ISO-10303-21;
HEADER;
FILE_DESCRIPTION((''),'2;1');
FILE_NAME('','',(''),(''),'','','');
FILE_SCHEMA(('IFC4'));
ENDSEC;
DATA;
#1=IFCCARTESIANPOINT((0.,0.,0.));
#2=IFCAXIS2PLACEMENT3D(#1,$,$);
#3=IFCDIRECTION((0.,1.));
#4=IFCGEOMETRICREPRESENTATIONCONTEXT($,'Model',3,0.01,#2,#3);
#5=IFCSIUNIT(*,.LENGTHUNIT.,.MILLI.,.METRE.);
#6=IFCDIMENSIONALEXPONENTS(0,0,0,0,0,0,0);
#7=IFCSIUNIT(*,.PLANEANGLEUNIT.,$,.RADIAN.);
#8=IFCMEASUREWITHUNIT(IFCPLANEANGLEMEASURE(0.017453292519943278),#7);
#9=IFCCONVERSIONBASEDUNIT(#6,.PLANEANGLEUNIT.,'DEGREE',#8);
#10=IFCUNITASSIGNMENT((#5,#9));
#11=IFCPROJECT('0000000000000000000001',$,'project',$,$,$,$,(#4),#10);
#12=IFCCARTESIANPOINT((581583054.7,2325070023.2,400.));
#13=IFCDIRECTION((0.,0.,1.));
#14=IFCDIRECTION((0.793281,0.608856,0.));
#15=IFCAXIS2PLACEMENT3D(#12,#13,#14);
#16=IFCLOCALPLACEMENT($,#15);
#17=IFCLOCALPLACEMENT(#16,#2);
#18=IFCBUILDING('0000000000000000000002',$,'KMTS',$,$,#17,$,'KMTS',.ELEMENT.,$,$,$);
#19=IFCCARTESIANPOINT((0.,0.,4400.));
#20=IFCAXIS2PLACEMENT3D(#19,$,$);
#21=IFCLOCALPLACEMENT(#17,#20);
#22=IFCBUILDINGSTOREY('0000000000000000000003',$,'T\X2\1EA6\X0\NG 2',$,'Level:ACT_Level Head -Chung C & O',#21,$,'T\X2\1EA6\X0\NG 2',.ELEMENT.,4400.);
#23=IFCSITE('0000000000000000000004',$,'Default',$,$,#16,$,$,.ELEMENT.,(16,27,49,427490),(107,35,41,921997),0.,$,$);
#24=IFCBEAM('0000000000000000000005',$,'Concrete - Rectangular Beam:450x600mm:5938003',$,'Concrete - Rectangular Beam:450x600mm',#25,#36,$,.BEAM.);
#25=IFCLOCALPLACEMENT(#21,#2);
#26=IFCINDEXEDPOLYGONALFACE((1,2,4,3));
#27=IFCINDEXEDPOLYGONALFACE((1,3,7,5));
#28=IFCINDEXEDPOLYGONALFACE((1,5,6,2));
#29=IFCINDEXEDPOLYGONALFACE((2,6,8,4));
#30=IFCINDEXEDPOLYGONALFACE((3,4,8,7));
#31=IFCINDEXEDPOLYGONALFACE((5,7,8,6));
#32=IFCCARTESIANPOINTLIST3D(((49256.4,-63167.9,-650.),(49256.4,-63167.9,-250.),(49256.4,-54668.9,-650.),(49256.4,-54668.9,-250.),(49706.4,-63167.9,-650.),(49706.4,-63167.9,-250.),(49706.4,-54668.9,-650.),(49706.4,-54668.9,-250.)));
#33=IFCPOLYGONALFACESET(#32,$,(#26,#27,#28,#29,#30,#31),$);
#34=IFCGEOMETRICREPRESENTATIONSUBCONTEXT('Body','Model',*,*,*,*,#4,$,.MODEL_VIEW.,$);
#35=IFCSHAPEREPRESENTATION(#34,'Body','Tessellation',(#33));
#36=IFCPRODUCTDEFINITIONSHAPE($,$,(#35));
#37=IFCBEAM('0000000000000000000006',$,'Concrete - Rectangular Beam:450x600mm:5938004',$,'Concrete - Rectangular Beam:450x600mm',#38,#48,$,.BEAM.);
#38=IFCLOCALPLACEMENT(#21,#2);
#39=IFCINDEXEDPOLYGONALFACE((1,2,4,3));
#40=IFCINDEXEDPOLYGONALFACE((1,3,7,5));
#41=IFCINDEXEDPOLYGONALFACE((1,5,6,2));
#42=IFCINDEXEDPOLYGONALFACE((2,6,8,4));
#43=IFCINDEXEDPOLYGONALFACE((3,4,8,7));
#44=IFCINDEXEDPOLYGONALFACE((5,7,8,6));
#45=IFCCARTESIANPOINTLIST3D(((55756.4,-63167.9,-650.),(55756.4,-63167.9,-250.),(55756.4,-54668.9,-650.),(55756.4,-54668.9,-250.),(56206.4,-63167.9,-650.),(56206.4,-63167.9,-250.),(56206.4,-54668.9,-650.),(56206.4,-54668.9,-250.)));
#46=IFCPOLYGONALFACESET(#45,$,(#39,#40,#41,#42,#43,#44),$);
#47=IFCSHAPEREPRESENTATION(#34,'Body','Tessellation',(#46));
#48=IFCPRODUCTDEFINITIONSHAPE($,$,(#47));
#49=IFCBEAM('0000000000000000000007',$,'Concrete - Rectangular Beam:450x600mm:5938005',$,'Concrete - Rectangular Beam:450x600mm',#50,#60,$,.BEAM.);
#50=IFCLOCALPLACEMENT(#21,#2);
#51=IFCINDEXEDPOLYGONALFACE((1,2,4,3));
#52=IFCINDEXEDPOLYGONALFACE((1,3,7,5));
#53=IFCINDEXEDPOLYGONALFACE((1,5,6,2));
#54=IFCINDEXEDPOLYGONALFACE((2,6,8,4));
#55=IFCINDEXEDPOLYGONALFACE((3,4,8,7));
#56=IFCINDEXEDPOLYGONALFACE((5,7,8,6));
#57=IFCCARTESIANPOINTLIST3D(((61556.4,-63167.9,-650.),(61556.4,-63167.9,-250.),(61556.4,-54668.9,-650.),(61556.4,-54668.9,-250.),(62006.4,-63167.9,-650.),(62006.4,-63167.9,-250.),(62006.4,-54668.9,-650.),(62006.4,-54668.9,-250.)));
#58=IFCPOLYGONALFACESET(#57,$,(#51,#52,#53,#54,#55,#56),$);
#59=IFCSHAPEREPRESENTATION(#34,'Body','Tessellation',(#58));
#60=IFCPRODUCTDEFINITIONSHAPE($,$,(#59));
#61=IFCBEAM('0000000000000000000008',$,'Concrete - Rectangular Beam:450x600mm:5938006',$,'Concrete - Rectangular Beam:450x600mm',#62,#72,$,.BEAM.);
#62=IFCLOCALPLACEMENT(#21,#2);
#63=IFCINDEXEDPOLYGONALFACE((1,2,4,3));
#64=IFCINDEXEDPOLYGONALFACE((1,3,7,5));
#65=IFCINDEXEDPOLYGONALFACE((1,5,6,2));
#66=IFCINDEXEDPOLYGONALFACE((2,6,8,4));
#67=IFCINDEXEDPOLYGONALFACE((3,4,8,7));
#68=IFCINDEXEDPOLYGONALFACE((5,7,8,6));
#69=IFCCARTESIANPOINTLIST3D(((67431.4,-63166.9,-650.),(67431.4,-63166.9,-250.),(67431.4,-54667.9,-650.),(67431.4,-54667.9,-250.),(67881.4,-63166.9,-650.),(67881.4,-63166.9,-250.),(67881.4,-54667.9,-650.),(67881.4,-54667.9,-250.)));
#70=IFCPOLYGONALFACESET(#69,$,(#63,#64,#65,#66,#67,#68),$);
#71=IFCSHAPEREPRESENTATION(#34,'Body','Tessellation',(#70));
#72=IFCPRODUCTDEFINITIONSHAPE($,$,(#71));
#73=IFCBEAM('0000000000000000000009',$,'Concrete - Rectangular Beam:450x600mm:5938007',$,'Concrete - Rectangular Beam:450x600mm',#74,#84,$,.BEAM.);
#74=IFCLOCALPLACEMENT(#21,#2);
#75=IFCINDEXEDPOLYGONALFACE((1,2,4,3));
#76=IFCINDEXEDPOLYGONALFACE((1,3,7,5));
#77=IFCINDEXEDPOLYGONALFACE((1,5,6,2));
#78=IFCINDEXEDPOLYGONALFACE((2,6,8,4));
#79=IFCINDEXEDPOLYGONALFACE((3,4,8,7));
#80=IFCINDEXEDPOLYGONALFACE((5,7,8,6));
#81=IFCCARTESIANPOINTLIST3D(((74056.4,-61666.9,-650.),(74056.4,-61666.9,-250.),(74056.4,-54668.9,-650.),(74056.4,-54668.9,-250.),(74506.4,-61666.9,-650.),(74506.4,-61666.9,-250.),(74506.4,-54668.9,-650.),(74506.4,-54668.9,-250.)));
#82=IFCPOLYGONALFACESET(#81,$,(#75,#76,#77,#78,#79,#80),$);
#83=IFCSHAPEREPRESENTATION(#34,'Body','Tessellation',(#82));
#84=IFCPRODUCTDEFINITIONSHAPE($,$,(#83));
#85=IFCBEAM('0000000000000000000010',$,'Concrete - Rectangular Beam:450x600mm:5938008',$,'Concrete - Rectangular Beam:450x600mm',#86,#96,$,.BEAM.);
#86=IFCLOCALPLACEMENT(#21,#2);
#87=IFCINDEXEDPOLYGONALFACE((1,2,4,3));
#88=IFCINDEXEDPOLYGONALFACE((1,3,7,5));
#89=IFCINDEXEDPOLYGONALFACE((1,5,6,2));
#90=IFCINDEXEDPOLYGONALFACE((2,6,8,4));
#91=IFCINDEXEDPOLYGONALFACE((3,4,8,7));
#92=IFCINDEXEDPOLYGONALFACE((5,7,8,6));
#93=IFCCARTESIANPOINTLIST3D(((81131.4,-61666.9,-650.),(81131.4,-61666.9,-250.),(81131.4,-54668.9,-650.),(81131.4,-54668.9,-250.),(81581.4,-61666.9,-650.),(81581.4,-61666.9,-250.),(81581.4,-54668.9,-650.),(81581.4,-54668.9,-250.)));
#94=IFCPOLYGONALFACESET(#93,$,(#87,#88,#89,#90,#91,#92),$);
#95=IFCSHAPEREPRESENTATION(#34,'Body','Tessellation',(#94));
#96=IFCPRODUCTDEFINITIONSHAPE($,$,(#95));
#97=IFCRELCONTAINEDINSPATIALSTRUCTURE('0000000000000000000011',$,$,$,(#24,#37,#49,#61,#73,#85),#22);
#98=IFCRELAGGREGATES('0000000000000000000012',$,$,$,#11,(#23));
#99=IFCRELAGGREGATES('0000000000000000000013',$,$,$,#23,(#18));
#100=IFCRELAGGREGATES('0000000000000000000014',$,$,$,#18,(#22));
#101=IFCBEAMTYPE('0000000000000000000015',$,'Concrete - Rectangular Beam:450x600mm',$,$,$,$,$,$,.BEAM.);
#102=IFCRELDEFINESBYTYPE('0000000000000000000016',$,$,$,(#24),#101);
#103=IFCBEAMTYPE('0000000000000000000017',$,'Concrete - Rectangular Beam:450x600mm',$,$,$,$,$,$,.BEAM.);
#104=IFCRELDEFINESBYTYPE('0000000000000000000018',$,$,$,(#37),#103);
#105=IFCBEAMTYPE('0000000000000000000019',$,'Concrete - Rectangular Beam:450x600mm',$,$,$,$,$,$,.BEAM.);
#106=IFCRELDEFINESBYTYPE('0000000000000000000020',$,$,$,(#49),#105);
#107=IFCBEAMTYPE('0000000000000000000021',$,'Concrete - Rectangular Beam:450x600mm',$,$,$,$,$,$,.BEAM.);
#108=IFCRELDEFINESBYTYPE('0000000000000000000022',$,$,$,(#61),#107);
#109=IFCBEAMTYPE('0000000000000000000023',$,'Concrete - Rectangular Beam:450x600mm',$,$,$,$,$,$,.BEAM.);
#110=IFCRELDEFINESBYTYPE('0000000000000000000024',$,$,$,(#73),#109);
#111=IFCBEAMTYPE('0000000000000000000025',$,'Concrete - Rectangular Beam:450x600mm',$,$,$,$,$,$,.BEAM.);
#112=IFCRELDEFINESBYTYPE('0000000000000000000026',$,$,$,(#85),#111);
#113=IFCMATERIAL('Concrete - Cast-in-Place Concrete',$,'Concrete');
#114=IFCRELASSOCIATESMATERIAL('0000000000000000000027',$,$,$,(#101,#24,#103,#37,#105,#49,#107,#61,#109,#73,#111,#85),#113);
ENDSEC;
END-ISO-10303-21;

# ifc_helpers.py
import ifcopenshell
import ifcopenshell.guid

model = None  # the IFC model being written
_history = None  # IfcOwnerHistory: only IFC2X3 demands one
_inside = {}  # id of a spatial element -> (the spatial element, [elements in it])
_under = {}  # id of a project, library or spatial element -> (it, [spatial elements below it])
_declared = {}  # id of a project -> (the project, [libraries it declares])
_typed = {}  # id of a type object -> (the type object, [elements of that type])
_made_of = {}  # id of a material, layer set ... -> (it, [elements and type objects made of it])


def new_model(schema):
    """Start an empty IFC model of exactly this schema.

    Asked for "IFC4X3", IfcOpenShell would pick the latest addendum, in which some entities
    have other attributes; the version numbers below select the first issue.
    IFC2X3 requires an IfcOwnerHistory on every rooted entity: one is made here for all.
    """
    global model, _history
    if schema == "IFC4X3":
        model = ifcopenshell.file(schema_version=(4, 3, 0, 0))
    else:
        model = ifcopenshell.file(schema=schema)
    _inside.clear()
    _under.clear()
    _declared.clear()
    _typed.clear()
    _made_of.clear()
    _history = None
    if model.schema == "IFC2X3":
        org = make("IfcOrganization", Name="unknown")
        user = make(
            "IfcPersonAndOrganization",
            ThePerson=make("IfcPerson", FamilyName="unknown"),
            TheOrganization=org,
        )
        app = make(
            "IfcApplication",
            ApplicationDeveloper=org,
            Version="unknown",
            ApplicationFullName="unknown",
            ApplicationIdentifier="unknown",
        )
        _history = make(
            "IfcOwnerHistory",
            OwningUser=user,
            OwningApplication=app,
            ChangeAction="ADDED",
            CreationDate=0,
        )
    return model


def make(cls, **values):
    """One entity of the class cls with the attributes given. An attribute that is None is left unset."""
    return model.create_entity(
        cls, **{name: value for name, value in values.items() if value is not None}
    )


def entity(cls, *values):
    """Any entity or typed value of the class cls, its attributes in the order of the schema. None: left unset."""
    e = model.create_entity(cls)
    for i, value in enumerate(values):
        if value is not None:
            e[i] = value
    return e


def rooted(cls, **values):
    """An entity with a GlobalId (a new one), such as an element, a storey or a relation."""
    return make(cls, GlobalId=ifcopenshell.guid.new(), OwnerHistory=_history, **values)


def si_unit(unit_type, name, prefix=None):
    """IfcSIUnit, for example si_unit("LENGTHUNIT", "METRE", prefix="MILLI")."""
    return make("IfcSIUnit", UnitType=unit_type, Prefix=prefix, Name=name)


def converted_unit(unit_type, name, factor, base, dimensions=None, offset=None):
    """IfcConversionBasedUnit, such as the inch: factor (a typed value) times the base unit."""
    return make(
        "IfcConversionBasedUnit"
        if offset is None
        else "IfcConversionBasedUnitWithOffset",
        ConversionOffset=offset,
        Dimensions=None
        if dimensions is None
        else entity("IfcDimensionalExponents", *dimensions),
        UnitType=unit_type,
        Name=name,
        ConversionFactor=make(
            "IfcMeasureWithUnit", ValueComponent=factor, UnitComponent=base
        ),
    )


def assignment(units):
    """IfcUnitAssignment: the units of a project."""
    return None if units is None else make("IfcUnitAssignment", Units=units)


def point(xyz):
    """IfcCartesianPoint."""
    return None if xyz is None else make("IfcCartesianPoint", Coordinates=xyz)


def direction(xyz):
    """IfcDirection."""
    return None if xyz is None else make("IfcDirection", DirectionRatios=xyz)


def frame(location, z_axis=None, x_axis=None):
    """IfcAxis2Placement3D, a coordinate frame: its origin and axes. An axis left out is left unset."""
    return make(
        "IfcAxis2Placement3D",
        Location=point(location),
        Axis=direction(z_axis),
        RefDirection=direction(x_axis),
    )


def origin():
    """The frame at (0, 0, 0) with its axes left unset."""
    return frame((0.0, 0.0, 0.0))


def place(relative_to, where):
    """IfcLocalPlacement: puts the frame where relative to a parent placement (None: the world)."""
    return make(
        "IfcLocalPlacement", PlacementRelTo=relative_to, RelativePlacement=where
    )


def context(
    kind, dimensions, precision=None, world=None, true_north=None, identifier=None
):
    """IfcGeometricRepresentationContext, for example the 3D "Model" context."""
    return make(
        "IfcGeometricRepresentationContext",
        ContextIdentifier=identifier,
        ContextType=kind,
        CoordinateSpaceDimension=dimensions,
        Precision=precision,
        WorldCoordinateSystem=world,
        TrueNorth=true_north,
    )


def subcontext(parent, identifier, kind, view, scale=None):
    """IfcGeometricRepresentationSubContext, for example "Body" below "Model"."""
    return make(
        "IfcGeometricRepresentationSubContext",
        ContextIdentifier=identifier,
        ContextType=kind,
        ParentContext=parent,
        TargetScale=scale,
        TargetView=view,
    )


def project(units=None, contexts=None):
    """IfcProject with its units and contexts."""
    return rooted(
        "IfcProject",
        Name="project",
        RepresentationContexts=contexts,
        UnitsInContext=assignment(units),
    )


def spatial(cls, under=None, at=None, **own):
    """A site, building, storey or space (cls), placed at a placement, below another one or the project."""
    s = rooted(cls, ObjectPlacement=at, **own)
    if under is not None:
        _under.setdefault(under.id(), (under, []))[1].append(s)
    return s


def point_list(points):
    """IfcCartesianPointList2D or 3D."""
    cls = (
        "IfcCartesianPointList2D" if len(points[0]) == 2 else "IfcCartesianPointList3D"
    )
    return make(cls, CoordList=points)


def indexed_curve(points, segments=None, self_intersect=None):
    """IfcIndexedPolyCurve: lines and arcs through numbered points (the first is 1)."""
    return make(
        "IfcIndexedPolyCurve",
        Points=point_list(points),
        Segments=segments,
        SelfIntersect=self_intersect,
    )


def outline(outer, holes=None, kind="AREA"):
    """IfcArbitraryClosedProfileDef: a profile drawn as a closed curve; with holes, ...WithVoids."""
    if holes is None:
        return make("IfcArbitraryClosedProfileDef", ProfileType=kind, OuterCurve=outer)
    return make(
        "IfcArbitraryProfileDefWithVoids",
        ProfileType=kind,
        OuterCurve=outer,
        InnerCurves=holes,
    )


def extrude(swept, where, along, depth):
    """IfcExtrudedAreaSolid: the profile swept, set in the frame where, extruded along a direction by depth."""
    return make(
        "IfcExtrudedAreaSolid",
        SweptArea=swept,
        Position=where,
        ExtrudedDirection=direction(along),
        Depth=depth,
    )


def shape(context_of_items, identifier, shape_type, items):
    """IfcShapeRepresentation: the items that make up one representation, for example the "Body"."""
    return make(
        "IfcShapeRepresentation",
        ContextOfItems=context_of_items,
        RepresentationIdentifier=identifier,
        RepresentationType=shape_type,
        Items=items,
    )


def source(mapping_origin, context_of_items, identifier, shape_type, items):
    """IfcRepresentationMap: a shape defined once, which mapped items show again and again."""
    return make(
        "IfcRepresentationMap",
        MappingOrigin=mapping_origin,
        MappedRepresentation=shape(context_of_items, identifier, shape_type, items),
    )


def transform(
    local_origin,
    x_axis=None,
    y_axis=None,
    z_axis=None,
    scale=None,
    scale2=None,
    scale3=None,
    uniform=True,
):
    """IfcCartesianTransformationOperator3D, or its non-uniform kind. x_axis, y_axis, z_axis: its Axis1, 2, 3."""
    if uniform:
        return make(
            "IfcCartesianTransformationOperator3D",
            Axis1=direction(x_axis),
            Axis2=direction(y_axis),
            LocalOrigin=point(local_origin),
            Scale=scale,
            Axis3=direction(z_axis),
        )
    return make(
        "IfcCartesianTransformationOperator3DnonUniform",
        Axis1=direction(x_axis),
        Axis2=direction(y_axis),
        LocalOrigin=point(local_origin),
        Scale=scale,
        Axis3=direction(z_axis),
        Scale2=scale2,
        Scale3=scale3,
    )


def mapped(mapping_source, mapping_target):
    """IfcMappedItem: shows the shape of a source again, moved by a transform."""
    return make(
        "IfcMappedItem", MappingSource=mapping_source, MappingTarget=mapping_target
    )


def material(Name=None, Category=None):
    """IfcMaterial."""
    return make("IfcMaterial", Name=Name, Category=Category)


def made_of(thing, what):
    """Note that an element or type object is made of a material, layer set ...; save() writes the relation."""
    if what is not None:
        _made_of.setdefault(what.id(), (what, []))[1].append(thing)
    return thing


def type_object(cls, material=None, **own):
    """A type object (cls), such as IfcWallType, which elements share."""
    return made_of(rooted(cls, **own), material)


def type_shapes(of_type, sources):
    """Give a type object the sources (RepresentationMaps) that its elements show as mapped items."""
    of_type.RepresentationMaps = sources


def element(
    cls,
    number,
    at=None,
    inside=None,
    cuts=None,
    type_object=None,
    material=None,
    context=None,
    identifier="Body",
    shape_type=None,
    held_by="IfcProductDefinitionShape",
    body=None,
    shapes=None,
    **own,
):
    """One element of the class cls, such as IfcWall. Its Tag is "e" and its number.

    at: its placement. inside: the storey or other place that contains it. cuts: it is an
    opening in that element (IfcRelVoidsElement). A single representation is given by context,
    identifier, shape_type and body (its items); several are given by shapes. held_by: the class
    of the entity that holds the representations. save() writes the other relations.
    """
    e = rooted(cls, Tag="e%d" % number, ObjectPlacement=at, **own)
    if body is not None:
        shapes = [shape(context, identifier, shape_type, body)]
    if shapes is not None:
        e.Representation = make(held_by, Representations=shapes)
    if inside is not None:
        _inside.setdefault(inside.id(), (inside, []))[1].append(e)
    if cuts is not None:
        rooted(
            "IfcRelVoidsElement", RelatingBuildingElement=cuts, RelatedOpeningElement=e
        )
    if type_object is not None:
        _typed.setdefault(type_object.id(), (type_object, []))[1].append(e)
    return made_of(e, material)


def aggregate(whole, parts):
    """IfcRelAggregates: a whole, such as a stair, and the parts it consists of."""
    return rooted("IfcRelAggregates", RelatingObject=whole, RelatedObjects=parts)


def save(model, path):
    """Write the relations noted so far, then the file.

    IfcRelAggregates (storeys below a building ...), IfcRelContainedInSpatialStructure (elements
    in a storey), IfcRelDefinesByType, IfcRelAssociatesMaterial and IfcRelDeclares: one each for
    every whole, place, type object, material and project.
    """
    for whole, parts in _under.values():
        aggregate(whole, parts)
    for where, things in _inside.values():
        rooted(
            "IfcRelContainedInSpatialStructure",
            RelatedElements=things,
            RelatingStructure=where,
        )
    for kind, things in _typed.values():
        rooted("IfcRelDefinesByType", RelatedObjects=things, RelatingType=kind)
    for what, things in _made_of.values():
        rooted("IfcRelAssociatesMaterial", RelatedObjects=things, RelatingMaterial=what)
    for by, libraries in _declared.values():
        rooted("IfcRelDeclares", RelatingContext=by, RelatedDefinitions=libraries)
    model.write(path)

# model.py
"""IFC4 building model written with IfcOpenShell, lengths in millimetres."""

from ifc_helpers import new_model, entity, si_unit, converted_unit, direction, frame, origin, place, context, subcontext, project, spatial, indexed_curve, outline, extrude, source, transform, mapped, material, type_object, type_shapes, element, save


model = new_model("IFC4")

# Units and contexts
model_context = context("Model", 3, precision=0.01, world=origin(), true_north=direction((0.0, 1.0)))
body_context = subcontext(model_context, "Body", "Model", "MODEL_VIEW")
ifc_project = project(units=[si_unit("LENGTHUNIT", "METRE", prefix="MILLI"), converted_unit("PLANEANGLEUNIT", "DEGREE", entity("IfcPlaneAngleMeasure", 0.017453292519943278), si_unit("PLANEANGLEUNIT", "RADIAN"), dimensions=[0, 0, 0, 0, 0, 0, 0])], contexts=[model_context])

# Site, building, storey
site_placement = place(None, frame((581583054.7, 2325070023.2, 400.0), z_axis=(0.0, 0.0, 1.0), x_axis=(0.793281, 0.608856, 0.0)))
site = spatial("IfcSite", under=ifc_project, at=site_placement, Name="Default", CompositionType="ELEMENT", RefLatitude=(16, 27, 49, 427490), RefLongitude=(107, 35, 41, 921997), RefElevation=0.0)
building_placement = place(site_placement, origin())
building = spatial("IfcBuilding", under=site, at=building_placement, Name="KMTS", LongName="KMTS", CompositionType="ELEMENT")
storey_placement = place(building_placement, frame((0.0, 0.0, 4400.0)))
storey = spatial("IfcBuildingStorey", under=building, at=storey_placement, Name="TẦNG 2", ObjectType="Level:ACT_Level Head -Chung C & O", LongName="TẦNG 2", CompositionType="ELEMENT", Elevation=4400.0)

# Beams
ifc_material = material(Name="Concrete - Cast-in-Place Concrete", Category="Concrete")
beam_type_1 = type_object("IfcBeamType", Name="Concrete - Rectangular Beam:450x600mm", PredefinedType="BEAM", material=ifc_material)
shared_shape_1 = source(origin(), body_context, "Body", "SweptSolid", [
    extrude(outline(indexed_curve([(-225.0, -200.0), (225.0, -200.0), (225.0, 200.0), (-225.0, 200.0), (-225.0, -200.0)], self_intersect=False)), frame((49481.4, -54668.9, 3950.0), z_axis=(0.0, -1.0, 0.0), x_axis=(-1.0, 0.0, 0.0)), (0.0, 0.0, 1.0), 8499.0),
])
type_shapes(beam_type_1, [shared_shape_1])
beam_1_placement = place(storey_placement, frame((0.0, 0.0, -4400.0)))
element("IfcBeam", 1, at=beam_1_placement, inside=storey, type_object=beam_type_1, material=ifc_material, Name="Concrete - Rectangular Beam:450x600mm:5938003", ObjectType="Concrete - Rectangular Beam:450x600mm", PredefinedType="BEAM", context=body_context, shape_type="MappedRepresentation", body=[
    mapped(shared_shape_1, transform((0.0, 0.0, 0.0), scale=1.0)),
])
beam_type_2 = type_object("IfcBeamType", Name="Concrete - Rectangular Beam:450x600mm", PredefinedType="BEAM", material=ifc_material)
shared_shape_2 = source(origin(), body_context, "Body", "SweptSolid", [
    extrude(outline(indexed_curve([(-225.0, -200.0), (225.0, -200.0), (225.0, 200.0), (-225.0, 200.0), (-225.0, -200.0)], self_intersect=False)), frame((55981.4, -54668.9, 3950.0), z_axis=(0.0, -1.0, 0.0), x_axis=(-1.0, 0.0, 0.0)), (0.0, 0.0, 1.0), 8499.0),
])
type_shapes(beam_type_2, [shared_shape_2])
beam_2_placement = place(storey_placement, frame((0.0, 0.0, -4400.0)))
element("IfcBeam", 2, at=beam_2_placement, inside=storey, type_object=beam_type_2, material=ifc_material, Name="Concrete - Rectangular Beam:450x600mm:5938004", ObjectType="Concrete - Rectangular Beam:450x600mm", PredefinedType="BEAM", context=body_context, shape_type="MappedRepresentation", body=[
    mapped(shared_shape_2, transform((0.0, 0.0, 0.0), scale=1.0)),
])
beam_type_3 = type_object("IfcBeamType", Name="Concrete - Rectangular Beam:450x600mm", PredefinedType="BEAM", material=ifc_material)
shared_shape_3 = source(origin(), body_context, "Body", "SweptSolid", [
    extrude(outline(indexed_curve([(-225.0, -200.0), (225.0, -200.0), (225.0, 200.0), (-225.0, 200.0), (-225.0, -200.0)], self_intersect=False)), frame((61781.4, -54668.9, 3950.0), z_axis=(0.0, -1.0, 0.0), x_axis=(-1.0, 0.0, 0.0)), (0.0, 0.0, 1.0), 8499.0),
])
type_shapes(beam_type_3, [shared_shape_3])
beam_3_placement = place(storey_placement, frame((0.0, 0.0, -4400.0)))
element("IfcBeam", 3, at=beam_3_placement, inside=storey, type_object=beam_type_3, material=ifc_material, Name="Concrete - Rectangular Beam:450x600mm:5938005", ObjectType="Concrete - Rectangular Beam:450x600mm", PredefinedType="BEAM", context=body_context, shape_type="MappedRepresentation", body=[
    mapped(shared_shape_3, transform((0.0, 0.0, 0.0), scale=1.0)),
])
beam_type_4 = type_object("IfcBeamType", Name="Concrete - Rectangular Beam:450x600mm", PredefinedType="BEAM", material=ifc_material)
shared_shape_4 = source(origin(), body_context, "Body", "SweptSolid", [
    extrude(outline(indexed_curve([(-225.0, -200.0), (225.0, -200.0), (225.0, 200.0), (-225.0, 200.0), (-225.0, -200.0)], self_intersect=False)), frame((67656.4, -54667.9, 3950.0), z_axis=(0.0, -1.0, 0.0), x_axis=(-1.0, 0.0, 0.0)), (0.0, 0.0, 1.0), 8499.0),
])
type_shapes(beam_type_4, [shared_shape_4])
beam_4_placement = place(storey_placement, frame((0.0, 0.0, -4400.0)))
element("IfcBeam", 4, at=beam_4_placement, inside=storey, type_object=beam_type_4, material=ifc_material, Name="Concrete - Rectangular Beam:450x600mm:5938006", ObjectType="Concrete - Rectangular Beam:450x600mm", PredefinedType="BEAM", context=body_context, shape_type="MappedRepresentation", body=[
    mapped(shared_shape_4, transform((0.0, 0.0, 0.0), scale=1.0)),
])
beam_type_5 = type_object("IfcBeamType", Name="Concrete - Rectangular Beam:450x600mm", PredefinedType="BEAM", material=ifc_material)
shared_shape_5 = source(origin(), body_context, "Body", "SweptSolid", [
    extrude(outline(indexed_curve([(-225.0, -200.0), (225.0, -200.0), (225.0, 200.0), (-225.0, 200.0), (-225.0, -200.0)], self_intersect=False)), frame((74281.4, -54668.9, 3950.0), z_axis=(0.0, -1.0, 0.0), x_axis=(-1.0, 0.0, 0.0)), (0.0, 0.0, 1.0), 6998.0),
])
type_shapes(beam_type_5, [shared_shape_5])
beam_5_placement = place(storey_placement, frame((0.0, 0.0, -4400.0)))
element("IfcBeam", 5, at=beam_5_placement, inside=storey, type_object=beam_type_5, material=ifc_material, Name="Concrete - Rectangular Beam:450x600mm:5938007", ObjectType="Concrete - Rectangular Beam:450x600mm", PredefinedType="BEAM", context=body_context, shape_type="MappedRepresentation", body=[
    mapped(shared_shape_5, transform((0.0, 0.0, 0.0), scale=1.0)),
])
beam_type_6 = type_object("IfcBeamType", Name="Concrete - Rectangular Beam:450x600mm", PredefinedType="BEAM", material=ifc_material)
shared_shape_6 = source(origin(), body_context, "Body", "SweptSolid", [
    extrude(outline(indexed_curve([(-225.0, -200.0), (225.0, -200.0), (225.0, 200.0), (-225.0, 200.0), (-225.0, -200.0)], self_intersect=False)), frame((81356.4, -54668.9, 3950.0), z_axis=(0.0, -1.0, 0.0), x_axis=(-1.0, 0.0, 0.0)), (0.0, 0.0, 1.0), 6998.0),
])
type_shapes(beam_type_6, [shared_shape_6])
beam_6_placement = place(storey_placement, frame((0.0, 0.0, -4400.0)))
element("IfcBeam", 6, at=beam_6_placement, inside=storey, type_object=beam_type_6, material=ifc_material, Name="Concrete - Rectangular Beam:450x600mm:5938008", ObjectType="Concrete - Rectangular Beam:450x600mm", PredefinedType="BEAM", context=body_context, shape_type="MappedRepresentation", body=[
    mapped(shared_shape_6, transform((0.0, 0.0, 0.0), scale=1.0)),
])

save(model, "model.ifc")
